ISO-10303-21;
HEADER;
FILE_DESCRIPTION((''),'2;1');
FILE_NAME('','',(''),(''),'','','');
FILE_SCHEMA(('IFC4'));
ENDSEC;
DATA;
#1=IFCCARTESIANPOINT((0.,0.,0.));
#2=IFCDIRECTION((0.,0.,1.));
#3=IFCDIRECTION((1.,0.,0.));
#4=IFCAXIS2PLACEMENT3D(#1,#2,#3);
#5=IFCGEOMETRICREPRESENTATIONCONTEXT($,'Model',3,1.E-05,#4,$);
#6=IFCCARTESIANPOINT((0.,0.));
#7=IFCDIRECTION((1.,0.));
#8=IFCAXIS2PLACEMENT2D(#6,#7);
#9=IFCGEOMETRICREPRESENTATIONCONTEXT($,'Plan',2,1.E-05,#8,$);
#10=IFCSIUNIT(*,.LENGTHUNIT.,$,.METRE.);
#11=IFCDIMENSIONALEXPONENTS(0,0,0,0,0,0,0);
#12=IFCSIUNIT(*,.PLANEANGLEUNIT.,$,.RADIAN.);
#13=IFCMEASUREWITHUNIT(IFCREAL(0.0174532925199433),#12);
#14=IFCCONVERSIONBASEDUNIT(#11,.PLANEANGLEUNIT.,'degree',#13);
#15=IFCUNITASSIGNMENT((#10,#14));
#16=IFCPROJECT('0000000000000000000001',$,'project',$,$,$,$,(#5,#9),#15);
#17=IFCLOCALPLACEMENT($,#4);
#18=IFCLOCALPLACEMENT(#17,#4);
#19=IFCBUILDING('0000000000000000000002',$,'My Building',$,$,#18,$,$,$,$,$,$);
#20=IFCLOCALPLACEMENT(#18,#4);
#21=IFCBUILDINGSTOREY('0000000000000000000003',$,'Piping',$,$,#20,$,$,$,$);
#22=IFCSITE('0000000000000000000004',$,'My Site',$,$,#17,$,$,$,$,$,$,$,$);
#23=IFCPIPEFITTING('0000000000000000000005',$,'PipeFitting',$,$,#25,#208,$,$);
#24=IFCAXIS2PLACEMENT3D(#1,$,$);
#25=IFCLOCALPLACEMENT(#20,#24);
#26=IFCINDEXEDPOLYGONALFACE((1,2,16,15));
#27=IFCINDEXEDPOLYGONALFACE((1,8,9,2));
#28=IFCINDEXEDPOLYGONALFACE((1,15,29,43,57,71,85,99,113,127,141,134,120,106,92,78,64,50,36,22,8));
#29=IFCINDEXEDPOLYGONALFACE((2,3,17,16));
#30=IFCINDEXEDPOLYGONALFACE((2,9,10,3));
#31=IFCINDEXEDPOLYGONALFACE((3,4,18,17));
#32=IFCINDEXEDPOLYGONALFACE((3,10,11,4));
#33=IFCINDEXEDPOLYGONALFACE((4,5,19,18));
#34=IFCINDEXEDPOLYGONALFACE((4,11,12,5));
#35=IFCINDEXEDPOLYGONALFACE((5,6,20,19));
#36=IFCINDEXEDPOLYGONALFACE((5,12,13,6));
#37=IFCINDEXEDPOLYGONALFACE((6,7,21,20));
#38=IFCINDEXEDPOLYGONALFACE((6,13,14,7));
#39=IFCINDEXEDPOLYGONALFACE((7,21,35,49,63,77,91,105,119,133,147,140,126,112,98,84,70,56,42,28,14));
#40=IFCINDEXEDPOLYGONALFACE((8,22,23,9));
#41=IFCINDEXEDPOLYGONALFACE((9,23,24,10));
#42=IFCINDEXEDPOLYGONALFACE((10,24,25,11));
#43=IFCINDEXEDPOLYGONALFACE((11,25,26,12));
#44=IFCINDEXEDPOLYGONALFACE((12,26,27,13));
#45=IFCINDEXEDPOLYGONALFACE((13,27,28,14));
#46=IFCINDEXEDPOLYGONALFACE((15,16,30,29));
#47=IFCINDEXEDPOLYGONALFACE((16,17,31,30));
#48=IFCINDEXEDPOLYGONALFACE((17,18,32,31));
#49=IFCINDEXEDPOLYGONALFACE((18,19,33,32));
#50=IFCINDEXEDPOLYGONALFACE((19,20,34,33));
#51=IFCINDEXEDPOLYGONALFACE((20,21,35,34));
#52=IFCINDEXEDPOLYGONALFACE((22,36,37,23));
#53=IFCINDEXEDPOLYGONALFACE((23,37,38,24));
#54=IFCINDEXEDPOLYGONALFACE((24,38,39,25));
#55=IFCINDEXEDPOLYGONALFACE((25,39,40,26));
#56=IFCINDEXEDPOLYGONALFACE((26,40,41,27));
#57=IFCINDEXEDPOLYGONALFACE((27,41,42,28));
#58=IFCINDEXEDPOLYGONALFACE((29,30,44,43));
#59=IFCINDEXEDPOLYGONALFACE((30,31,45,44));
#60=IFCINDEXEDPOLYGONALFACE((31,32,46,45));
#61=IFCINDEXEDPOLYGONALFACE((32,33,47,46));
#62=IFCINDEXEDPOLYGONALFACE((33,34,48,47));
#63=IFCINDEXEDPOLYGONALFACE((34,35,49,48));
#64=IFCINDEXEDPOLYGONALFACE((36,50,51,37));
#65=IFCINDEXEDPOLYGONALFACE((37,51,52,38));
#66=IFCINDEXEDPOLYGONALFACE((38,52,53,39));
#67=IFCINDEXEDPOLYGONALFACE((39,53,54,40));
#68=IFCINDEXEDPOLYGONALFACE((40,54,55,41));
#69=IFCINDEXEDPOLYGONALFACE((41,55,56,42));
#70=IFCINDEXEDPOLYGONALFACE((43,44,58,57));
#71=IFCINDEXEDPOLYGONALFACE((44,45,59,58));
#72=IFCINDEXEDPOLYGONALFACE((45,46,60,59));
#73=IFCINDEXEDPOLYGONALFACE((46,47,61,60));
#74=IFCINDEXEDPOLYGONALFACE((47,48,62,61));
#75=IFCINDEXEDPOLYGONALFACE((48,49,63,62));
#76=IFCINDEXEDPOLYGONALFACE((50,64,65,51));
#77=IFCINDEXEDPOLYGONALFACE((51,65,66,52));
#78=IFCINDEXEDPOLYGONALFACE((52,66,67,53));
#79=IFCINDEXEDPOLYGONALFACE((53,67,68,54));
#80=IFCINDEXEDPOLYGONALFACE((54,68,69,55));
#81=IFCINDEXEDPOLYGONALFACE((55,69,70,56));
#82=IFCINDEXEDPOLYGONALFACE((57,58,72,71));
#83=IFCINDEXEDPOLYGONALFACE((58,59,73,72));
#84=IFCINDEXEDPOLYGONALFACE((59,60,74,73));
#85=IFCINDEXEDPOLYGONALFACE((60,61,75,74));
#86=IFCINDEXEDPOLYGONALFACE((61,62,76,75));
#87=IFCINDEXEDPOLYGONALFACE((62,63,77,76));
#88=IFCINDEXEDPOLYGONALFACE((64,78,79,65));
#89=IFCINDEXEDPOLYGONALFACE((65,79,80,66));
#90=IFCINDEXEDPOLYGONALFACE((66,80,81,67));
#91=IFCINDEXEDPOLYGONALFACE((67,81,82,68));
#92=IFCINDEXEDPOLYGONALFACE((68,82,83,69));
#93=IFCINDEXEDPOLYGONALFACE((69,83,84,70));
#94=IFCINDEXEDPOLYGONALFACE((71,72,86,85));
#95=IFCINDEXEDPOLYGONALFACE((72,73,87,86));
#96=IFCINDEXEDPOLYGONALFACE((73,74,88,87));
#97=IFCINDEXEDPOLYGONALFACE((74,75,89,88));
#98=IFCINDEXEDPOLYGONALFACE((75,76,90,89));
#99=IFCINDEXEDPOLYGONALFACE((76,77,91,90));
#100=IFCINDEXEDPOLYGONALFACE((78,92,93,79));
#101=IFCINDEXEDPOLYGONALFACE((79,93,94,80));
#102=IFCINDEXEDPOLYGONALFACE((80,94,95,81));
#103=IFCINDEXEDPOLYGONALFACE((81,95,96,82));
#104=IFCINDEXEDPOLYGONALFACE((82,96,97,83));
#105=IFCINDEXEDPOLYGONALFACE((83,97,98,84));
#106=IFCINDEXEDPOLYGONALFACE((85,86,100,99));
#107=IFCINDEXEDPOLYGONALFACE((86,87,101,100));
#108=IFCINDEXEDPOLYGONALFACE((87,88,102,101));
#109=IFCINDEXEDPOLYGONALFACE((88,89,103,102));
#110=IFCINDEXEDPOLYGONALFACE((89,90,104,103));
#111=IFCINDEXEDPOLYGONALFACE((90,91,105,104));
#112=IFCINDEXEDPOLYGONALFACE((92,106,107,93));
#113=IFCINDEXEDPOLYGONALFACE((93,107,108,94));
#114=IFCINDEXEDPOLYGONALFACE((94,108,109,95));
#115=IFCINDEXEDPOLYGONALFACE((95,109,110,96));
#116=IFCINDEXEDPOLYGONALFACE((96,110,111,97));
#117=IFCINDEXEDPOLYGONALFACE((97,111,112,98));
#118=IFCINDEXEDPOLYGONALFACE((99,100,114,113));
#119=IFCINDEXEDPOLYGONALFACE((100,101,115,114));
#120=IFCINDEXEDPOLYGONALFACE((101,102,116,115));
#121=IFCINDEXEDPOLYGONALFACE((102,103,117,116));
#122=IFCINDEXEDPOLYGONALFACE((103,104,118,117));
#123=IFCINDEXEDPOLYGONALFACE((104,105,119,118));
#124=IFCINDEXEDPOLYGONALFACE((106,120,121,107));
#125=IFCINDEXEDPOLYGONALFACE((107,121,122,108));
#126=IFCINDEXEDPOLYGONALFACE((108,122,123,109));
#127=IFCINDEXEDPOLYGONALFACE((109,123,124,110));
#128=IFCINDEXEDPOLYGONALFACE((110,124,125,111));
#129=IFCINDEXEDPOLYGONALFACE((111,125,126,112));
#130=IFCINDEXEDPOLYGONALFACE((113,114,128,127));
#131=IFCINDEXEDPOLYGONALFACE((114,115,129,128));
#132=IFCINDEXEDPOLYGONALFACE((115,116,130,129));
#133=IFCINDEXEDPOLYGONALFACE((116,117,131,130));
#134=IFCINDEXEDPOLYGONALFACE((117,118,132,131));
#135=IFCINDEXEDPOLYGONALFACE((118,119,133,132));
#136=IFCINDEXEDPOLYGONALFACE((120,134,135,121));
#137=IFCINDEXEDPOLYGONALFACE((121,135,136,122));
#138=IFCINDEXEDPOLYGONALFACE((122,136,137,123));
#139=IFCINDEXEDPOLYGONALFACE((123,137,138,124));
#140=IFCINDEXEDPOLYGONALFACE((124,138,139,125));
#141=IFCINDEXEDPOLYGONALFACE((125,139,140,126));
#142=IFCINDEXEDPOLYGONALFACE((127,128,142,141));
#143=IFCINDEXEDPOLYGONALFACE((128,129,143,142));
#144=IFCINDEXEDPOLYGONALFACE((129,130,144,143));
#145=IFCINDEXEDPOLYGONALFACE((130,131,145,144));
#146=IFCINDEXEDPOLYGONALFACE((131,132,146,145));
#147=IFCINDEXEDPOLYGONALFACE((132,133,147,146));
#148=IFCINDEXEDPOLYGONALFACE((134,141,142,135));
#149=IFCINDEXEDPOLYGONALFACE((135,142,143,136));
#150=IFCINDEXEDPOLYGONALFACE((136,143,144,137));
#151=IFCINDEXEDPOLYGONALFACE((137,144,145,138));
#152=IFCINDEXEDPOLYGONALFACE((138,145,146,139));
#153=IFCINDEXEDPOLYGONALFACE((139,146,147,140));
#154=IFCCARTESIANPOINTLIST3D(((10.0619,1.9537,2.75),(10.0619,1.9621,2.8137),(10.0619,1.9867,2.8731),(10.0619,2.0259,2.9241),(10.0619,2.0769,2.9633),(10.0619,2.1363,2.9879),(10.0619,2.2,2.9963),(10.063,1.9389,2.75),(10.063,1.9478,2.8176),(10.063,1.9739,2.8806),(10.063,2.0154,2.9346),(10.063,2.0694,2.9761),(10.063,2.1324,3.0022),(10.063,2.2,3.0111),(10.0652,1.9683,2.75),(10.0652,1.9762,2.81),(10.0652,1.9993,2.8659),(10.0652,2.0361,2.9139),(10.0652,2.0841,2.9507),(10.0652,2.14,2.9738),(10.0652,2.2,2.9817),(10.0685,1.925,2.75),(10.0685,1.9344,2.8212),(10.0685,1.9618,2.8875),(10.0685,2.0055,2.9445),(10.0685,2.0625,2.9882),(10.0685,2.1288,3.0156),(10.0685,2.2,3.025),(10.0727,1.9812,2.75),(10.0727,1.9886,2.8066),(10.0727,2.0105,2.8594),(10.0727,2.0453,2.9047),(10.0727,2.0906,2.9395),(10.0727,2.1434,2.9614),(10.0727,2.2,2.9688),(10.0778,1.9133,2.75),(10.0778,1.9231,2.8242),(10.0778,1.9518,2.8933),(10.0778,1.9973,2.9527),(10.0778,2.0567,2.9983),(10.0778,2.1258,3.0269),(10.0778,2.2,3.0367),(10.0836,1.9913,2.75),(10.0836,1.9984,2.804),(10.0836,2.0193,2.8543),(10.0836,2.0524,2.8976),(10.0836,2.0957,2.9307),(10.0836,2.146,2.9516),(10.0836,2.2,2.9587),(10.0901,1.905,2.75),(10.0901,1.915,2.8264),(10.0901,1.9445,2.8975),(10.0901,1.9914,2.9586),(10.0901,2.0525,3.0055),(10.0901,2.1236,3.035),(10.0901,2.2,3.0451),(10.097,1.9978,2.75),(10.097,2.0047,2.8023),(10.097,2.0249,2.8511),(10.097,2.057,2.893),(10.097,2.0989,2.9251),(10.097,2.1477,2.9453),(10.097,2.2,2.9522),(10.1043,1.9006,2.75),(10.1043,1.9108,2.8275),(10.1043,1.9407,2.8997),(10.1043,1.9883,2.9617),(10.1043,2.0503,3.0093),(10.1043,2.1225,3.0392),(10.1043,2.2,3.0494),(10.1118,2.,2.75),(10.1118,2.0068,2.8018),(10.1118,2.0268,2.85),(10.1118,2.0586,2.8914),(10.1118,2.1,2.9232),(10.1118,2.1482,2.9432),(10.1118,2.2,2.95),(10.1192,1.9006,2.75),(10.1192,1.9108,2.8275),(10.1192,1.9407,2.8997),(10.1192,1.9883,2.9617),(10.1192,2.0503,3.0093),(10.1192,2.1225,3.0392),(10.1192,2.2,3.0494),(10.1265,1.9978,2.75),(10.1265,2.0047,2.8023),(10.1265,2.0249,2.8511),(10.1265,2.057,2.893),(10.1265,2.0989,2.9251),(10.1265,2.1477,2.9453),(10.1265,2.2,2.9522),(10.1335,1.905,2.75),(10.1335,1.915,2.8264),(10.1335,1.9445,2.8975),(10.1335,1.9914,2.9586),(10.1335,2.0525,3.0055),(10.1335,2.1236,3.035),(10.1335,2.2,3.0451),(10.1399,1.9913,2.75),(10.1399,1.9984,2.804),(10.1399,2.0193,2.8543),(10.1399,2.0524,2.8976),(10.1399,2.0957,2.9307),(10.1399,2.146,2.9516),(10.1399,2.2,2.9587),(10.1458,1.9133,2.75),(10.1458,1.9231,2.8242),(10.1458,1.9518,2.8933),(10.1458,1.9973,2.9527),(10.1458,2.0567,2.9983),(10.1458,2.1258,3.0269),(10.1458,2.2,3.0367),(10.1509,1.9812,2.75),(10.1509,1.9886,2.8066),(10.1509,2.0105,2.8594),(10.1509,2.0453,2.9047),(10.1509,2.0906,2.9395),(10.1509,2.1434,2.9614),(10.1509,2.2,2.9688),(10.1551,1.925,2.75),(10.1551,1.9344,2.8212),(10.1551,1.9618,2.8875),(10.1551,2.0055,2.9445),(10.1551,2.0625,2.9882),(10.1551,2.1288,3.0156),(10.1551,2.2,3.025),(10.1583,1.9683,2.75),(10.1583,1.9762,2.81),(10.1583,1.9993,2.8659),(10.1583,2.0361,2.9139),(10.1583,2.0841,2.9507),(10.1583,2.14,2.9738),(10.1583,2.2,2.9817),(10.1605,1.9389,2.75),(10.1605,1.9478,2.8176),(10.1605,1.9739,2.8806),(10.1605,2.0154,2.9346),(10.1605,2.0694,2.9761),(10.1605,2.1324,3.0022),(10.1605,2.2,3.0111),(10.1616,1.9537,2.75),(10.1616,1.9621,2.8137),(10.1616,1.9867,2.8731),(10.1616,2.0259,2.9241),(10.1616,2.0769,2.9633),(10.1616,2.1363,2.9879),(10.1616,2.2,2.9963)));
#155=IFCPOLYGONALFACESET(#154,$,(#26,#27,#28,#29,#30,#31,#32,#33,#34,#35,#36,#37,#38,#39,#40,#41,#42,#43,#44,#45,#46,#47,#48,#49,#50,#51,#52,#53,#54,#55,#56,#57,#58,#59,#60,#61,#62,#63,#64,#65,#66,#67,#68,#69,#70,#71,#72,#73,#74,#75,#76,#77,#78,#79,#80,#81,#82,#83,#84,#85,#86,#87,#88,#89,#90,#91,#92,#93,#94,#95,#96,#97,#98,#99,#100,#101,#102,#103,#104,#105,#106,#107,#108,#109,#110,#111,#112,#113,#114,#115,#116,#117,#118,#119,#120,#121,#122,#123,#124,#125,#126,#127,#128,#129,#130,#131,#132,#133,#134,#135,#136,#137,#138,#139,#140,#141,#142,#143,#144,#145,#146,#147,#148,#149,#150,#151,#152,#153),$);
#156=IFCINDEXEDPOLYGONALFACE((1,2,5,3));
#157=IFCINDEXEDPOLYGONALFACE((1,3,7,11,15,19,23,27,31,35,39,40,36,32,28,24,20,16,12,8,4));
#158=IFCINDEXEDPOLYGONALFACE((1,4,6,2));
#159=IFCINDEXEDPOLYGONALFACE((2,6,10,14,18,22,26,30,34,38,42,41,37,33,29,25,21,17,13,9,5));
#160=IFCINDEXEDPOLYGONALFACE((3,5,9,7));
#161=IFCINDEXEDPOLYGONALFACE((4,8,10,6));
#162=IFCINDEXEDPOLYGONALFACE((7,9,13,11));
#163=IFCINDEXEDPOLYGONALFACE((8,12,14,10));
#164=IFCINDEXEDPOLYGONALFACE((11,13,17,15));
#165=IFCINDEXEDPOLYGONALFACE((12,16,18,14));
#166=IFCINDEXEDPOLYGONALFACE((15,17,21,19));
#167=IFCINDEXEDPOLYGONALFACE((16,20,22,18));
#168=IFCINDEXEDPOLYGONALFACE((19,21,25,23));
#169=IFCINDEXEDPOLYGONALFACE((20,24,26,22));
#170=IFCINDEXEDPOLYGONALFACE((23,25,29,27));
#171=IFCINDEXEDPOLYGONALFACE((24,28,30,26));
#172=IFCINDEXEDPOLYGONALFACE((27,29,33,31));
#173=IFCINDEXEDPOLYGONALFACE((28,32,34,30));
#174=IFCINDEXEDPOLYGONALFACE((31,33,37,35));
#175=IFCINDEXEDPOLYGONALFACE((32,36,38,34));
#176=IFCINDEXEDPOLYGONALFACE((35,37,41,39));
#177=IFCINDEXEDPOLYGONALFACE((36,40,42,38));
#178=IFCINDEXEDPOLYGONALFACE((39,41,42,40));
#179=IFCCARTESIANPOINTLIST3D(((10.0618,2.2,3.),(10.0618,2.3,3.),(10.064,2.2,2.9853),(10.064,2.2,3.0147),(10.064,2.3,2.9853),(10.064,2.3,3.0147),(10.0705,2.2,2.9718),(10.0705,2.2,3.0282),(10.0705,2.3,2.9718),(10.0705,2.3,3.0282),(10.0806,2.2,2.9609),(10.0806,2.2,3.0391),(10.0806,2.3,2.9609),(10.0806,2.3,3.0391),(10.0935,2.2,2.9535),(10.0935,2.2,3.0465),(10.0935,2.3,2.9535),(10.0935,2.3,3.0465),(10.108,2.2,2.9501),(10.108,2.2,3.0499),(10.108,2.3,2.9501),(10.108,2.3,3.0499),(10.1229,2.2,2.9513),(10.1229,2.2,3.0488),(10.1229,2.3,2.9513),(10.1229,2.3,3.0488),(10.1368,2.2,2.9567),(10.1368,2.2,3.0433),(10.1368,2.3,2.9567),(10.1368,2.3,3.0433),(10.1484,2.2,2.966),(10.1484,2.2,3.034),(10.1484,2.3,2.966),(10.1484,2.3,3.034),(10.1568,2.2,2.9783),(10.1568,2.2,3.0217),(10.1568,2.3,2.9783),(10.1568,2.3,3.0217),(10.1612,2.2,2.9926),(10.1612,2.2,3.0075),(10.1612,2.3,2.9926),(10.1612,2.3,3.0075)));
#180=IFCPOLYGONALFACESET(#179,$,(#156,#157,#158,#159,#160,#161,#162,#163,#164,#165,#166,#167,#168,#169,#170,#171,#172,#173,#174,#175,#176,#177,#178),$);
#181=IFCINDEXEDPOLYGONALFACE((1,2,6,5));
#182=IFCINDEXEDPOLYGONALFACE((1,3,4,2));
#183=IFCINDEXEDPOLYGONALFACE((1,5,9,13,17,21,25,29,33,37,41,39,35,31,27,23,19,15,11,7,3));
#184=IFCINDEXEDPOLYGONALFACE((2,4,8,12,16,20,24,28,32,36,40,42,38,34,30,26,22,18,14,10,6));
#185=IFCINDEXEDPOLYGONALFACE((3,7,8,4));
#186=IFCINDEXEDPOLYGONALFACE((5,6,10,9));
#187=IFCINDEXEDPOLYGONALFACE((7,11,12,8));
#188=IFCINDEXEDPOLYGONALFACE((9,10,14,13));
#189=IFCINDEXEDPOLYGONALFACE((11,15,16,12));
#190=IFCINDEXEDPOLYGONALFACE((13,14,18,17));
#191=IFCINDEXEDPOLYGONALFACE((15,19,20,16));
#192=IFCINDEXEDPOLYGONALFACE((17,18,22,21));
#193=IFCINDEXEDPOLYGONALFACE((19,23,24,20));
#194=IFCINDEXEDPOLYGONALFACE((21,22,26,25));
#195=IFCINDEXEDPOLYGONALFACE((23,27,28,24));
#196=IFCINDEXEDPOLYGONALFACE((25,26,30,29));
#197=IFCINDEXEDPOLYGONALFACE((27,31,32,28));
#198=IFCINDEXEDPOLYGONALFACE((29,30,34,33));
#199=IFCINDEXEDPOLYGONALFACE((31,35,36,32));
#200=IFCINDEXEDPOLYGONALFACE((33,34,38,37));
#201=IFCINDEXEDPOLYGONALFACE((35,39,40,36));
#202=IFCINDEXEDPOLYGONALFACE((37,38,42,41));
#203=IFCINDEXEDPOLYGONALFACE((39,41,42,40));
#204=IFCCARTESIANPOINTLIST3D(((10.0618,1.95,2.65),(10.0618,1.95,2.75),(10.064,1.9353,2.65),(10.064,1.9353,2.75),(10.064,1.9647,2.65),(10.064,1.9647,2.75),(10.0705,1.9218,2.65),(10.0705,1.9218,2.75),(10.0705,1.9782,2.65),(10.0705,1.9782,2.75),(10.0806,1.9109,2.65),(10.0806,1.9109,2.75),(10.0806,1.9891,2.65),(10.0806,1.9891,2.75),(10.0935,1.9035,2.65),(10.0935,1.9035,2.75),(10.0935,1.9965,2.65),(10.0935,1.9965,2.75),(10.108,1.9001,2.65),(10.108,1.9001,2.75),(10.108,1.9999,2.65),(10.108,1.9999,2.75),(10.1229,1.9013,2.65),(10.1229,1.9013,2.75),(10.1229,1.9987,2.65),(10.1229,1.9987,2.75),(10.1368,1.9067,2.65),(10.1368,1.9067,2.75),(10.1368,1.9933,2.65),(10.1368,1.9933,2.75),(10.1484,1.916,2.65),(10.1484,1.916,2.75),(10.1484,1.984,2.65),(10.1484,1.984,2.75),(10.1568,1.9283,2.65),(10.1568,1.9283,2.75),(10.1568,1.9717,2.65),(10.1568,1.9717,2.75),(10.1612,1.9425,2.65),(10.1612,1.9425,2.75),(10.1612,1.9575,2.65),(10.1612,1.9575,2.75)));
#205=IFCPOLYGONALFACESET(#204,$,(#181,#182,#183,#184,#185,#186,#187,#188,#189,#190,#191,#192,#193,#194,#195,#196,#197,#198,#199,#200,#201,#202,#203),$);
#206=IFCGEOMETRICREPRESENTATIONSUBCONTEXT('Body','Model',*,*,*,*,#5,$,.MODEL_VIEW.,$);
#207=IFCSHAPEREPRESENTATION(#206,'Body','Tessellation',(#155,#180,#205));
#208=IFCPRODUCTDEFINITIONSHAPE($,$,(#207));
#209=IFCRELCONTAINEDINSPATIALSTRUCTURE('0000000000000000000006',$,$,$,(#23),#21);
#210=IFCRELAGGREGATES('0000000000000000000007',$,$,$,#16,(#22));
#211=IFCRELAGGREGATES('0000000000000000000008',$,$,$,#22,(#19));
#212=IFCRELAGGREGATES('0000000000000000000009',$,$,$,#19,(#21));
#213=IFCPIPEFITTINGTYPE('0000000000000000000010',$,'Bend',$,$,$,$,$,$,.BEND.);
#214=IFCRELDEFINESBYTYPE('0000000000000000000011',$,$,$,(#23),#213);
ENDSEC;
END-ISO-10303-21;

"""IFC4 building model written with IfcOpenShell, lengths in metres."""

from ifc_helpers import new_model, entity, si_unit, converted_unit, frame, origin_with_axes, origin_2d_with_axis, place, context, subcontext, project, spatial, circle, extrude, source, transform, mapped, type_object, type_shapes, element, save


model = new_model("IFC4")

# Units and contexts
model_context = context("Model", 3, precision=1e-05, world=origin_with_axes())
plan_context = context("Plan", 2, precision=1e-05, world=origin_2d_with_axis())
body_context = subcontext(model_context, "Body", "Model", "MODEL_VIEW")
ifc_project = project(units=[si_unit("LENGTHUNIT", "METRE"), converted_unit("PLANEANGLEUNIT", "degree", entity("IfcReal", 0.0174532925199433), si_unit("PLANEANGLEUNIT", "RADIAN"), dimensions=[0, 0, 0, 0, 0, 0, 0])], contexts=[model_context, plan_context])

# Site, building, storey
site_placement = place(None, origin_with_axes())
site = spatial("IfcSite", under=ifc_project, at=site_placement, Name="My Site")
building_placement = place(site_placement, origin_with_axes())
building = spatial("IfcBuilding", under=site, at=building_placement, Name="My Building")
storey_placement = place(building_placement, origin_with_axes())
storey = spatial("IfcBuildingStorey", under=building, at=storey_placement, Name="Piping")

# Pipe fitting
pipe_fitting_type = type_object("IfcPipeFittingType", Name="Bend", PredefinedType="BEND")
shared_shape = source(origin_with_axes(), body_context, "Body", "SolidModel", [
    entity("IfcSweptDiskSolid", entity("IfcIndexedPolyCurve", entity("IfcCartesianPointList3D", [[0.0, 0.0, -0.1], [0.0, -0.0732, -0.2768], [0.0, -0.25, -0.35]]), [entity("IfcArcIndex", [1, 2, 3])]), 0.05),
    extrude(circle(Radius=0.05), origin_with_axes(), (0.0, 0.0, -1.0), 0.1),
    extrude(circle(Radius=0.05), frame((0.0, -0.25, -0.35), z_axis=(0.0, -1.0, 0.0), x_axis=(1.0, 0.0, 0.0)), (0.0, 0.0, 1.0), 0.1),
])
type_shapes(pipe_fitting_type, [shared_shape])
for number, where, z_axis, x_axis, name in (
    (1, (10.1118, 2.3, 3.0), (0.0, 1.0, 0.0), (-1.0, 0.0, 0.0), "PipeFitting"),
):
    element("IfcPipeFitting", number, at=place(storey_placement, frame(where, z_axis=z_axis, x_axis=x_axis)), inside=storey, type_object=pipe_fitting_type, Name=name, context=body_context, shape_type="MappedRepresentation", body=[
        mapped(shared_shape, transform((0.0, 0.0, 0.0), x_axis=(1.0, 0.0, 0.0), y_axis=(0.0, 1.0, 0.0), z_axis=(0.0, 0.0, 1.0), scale=1.0)),
    ])

save(model, "model.ifc")
